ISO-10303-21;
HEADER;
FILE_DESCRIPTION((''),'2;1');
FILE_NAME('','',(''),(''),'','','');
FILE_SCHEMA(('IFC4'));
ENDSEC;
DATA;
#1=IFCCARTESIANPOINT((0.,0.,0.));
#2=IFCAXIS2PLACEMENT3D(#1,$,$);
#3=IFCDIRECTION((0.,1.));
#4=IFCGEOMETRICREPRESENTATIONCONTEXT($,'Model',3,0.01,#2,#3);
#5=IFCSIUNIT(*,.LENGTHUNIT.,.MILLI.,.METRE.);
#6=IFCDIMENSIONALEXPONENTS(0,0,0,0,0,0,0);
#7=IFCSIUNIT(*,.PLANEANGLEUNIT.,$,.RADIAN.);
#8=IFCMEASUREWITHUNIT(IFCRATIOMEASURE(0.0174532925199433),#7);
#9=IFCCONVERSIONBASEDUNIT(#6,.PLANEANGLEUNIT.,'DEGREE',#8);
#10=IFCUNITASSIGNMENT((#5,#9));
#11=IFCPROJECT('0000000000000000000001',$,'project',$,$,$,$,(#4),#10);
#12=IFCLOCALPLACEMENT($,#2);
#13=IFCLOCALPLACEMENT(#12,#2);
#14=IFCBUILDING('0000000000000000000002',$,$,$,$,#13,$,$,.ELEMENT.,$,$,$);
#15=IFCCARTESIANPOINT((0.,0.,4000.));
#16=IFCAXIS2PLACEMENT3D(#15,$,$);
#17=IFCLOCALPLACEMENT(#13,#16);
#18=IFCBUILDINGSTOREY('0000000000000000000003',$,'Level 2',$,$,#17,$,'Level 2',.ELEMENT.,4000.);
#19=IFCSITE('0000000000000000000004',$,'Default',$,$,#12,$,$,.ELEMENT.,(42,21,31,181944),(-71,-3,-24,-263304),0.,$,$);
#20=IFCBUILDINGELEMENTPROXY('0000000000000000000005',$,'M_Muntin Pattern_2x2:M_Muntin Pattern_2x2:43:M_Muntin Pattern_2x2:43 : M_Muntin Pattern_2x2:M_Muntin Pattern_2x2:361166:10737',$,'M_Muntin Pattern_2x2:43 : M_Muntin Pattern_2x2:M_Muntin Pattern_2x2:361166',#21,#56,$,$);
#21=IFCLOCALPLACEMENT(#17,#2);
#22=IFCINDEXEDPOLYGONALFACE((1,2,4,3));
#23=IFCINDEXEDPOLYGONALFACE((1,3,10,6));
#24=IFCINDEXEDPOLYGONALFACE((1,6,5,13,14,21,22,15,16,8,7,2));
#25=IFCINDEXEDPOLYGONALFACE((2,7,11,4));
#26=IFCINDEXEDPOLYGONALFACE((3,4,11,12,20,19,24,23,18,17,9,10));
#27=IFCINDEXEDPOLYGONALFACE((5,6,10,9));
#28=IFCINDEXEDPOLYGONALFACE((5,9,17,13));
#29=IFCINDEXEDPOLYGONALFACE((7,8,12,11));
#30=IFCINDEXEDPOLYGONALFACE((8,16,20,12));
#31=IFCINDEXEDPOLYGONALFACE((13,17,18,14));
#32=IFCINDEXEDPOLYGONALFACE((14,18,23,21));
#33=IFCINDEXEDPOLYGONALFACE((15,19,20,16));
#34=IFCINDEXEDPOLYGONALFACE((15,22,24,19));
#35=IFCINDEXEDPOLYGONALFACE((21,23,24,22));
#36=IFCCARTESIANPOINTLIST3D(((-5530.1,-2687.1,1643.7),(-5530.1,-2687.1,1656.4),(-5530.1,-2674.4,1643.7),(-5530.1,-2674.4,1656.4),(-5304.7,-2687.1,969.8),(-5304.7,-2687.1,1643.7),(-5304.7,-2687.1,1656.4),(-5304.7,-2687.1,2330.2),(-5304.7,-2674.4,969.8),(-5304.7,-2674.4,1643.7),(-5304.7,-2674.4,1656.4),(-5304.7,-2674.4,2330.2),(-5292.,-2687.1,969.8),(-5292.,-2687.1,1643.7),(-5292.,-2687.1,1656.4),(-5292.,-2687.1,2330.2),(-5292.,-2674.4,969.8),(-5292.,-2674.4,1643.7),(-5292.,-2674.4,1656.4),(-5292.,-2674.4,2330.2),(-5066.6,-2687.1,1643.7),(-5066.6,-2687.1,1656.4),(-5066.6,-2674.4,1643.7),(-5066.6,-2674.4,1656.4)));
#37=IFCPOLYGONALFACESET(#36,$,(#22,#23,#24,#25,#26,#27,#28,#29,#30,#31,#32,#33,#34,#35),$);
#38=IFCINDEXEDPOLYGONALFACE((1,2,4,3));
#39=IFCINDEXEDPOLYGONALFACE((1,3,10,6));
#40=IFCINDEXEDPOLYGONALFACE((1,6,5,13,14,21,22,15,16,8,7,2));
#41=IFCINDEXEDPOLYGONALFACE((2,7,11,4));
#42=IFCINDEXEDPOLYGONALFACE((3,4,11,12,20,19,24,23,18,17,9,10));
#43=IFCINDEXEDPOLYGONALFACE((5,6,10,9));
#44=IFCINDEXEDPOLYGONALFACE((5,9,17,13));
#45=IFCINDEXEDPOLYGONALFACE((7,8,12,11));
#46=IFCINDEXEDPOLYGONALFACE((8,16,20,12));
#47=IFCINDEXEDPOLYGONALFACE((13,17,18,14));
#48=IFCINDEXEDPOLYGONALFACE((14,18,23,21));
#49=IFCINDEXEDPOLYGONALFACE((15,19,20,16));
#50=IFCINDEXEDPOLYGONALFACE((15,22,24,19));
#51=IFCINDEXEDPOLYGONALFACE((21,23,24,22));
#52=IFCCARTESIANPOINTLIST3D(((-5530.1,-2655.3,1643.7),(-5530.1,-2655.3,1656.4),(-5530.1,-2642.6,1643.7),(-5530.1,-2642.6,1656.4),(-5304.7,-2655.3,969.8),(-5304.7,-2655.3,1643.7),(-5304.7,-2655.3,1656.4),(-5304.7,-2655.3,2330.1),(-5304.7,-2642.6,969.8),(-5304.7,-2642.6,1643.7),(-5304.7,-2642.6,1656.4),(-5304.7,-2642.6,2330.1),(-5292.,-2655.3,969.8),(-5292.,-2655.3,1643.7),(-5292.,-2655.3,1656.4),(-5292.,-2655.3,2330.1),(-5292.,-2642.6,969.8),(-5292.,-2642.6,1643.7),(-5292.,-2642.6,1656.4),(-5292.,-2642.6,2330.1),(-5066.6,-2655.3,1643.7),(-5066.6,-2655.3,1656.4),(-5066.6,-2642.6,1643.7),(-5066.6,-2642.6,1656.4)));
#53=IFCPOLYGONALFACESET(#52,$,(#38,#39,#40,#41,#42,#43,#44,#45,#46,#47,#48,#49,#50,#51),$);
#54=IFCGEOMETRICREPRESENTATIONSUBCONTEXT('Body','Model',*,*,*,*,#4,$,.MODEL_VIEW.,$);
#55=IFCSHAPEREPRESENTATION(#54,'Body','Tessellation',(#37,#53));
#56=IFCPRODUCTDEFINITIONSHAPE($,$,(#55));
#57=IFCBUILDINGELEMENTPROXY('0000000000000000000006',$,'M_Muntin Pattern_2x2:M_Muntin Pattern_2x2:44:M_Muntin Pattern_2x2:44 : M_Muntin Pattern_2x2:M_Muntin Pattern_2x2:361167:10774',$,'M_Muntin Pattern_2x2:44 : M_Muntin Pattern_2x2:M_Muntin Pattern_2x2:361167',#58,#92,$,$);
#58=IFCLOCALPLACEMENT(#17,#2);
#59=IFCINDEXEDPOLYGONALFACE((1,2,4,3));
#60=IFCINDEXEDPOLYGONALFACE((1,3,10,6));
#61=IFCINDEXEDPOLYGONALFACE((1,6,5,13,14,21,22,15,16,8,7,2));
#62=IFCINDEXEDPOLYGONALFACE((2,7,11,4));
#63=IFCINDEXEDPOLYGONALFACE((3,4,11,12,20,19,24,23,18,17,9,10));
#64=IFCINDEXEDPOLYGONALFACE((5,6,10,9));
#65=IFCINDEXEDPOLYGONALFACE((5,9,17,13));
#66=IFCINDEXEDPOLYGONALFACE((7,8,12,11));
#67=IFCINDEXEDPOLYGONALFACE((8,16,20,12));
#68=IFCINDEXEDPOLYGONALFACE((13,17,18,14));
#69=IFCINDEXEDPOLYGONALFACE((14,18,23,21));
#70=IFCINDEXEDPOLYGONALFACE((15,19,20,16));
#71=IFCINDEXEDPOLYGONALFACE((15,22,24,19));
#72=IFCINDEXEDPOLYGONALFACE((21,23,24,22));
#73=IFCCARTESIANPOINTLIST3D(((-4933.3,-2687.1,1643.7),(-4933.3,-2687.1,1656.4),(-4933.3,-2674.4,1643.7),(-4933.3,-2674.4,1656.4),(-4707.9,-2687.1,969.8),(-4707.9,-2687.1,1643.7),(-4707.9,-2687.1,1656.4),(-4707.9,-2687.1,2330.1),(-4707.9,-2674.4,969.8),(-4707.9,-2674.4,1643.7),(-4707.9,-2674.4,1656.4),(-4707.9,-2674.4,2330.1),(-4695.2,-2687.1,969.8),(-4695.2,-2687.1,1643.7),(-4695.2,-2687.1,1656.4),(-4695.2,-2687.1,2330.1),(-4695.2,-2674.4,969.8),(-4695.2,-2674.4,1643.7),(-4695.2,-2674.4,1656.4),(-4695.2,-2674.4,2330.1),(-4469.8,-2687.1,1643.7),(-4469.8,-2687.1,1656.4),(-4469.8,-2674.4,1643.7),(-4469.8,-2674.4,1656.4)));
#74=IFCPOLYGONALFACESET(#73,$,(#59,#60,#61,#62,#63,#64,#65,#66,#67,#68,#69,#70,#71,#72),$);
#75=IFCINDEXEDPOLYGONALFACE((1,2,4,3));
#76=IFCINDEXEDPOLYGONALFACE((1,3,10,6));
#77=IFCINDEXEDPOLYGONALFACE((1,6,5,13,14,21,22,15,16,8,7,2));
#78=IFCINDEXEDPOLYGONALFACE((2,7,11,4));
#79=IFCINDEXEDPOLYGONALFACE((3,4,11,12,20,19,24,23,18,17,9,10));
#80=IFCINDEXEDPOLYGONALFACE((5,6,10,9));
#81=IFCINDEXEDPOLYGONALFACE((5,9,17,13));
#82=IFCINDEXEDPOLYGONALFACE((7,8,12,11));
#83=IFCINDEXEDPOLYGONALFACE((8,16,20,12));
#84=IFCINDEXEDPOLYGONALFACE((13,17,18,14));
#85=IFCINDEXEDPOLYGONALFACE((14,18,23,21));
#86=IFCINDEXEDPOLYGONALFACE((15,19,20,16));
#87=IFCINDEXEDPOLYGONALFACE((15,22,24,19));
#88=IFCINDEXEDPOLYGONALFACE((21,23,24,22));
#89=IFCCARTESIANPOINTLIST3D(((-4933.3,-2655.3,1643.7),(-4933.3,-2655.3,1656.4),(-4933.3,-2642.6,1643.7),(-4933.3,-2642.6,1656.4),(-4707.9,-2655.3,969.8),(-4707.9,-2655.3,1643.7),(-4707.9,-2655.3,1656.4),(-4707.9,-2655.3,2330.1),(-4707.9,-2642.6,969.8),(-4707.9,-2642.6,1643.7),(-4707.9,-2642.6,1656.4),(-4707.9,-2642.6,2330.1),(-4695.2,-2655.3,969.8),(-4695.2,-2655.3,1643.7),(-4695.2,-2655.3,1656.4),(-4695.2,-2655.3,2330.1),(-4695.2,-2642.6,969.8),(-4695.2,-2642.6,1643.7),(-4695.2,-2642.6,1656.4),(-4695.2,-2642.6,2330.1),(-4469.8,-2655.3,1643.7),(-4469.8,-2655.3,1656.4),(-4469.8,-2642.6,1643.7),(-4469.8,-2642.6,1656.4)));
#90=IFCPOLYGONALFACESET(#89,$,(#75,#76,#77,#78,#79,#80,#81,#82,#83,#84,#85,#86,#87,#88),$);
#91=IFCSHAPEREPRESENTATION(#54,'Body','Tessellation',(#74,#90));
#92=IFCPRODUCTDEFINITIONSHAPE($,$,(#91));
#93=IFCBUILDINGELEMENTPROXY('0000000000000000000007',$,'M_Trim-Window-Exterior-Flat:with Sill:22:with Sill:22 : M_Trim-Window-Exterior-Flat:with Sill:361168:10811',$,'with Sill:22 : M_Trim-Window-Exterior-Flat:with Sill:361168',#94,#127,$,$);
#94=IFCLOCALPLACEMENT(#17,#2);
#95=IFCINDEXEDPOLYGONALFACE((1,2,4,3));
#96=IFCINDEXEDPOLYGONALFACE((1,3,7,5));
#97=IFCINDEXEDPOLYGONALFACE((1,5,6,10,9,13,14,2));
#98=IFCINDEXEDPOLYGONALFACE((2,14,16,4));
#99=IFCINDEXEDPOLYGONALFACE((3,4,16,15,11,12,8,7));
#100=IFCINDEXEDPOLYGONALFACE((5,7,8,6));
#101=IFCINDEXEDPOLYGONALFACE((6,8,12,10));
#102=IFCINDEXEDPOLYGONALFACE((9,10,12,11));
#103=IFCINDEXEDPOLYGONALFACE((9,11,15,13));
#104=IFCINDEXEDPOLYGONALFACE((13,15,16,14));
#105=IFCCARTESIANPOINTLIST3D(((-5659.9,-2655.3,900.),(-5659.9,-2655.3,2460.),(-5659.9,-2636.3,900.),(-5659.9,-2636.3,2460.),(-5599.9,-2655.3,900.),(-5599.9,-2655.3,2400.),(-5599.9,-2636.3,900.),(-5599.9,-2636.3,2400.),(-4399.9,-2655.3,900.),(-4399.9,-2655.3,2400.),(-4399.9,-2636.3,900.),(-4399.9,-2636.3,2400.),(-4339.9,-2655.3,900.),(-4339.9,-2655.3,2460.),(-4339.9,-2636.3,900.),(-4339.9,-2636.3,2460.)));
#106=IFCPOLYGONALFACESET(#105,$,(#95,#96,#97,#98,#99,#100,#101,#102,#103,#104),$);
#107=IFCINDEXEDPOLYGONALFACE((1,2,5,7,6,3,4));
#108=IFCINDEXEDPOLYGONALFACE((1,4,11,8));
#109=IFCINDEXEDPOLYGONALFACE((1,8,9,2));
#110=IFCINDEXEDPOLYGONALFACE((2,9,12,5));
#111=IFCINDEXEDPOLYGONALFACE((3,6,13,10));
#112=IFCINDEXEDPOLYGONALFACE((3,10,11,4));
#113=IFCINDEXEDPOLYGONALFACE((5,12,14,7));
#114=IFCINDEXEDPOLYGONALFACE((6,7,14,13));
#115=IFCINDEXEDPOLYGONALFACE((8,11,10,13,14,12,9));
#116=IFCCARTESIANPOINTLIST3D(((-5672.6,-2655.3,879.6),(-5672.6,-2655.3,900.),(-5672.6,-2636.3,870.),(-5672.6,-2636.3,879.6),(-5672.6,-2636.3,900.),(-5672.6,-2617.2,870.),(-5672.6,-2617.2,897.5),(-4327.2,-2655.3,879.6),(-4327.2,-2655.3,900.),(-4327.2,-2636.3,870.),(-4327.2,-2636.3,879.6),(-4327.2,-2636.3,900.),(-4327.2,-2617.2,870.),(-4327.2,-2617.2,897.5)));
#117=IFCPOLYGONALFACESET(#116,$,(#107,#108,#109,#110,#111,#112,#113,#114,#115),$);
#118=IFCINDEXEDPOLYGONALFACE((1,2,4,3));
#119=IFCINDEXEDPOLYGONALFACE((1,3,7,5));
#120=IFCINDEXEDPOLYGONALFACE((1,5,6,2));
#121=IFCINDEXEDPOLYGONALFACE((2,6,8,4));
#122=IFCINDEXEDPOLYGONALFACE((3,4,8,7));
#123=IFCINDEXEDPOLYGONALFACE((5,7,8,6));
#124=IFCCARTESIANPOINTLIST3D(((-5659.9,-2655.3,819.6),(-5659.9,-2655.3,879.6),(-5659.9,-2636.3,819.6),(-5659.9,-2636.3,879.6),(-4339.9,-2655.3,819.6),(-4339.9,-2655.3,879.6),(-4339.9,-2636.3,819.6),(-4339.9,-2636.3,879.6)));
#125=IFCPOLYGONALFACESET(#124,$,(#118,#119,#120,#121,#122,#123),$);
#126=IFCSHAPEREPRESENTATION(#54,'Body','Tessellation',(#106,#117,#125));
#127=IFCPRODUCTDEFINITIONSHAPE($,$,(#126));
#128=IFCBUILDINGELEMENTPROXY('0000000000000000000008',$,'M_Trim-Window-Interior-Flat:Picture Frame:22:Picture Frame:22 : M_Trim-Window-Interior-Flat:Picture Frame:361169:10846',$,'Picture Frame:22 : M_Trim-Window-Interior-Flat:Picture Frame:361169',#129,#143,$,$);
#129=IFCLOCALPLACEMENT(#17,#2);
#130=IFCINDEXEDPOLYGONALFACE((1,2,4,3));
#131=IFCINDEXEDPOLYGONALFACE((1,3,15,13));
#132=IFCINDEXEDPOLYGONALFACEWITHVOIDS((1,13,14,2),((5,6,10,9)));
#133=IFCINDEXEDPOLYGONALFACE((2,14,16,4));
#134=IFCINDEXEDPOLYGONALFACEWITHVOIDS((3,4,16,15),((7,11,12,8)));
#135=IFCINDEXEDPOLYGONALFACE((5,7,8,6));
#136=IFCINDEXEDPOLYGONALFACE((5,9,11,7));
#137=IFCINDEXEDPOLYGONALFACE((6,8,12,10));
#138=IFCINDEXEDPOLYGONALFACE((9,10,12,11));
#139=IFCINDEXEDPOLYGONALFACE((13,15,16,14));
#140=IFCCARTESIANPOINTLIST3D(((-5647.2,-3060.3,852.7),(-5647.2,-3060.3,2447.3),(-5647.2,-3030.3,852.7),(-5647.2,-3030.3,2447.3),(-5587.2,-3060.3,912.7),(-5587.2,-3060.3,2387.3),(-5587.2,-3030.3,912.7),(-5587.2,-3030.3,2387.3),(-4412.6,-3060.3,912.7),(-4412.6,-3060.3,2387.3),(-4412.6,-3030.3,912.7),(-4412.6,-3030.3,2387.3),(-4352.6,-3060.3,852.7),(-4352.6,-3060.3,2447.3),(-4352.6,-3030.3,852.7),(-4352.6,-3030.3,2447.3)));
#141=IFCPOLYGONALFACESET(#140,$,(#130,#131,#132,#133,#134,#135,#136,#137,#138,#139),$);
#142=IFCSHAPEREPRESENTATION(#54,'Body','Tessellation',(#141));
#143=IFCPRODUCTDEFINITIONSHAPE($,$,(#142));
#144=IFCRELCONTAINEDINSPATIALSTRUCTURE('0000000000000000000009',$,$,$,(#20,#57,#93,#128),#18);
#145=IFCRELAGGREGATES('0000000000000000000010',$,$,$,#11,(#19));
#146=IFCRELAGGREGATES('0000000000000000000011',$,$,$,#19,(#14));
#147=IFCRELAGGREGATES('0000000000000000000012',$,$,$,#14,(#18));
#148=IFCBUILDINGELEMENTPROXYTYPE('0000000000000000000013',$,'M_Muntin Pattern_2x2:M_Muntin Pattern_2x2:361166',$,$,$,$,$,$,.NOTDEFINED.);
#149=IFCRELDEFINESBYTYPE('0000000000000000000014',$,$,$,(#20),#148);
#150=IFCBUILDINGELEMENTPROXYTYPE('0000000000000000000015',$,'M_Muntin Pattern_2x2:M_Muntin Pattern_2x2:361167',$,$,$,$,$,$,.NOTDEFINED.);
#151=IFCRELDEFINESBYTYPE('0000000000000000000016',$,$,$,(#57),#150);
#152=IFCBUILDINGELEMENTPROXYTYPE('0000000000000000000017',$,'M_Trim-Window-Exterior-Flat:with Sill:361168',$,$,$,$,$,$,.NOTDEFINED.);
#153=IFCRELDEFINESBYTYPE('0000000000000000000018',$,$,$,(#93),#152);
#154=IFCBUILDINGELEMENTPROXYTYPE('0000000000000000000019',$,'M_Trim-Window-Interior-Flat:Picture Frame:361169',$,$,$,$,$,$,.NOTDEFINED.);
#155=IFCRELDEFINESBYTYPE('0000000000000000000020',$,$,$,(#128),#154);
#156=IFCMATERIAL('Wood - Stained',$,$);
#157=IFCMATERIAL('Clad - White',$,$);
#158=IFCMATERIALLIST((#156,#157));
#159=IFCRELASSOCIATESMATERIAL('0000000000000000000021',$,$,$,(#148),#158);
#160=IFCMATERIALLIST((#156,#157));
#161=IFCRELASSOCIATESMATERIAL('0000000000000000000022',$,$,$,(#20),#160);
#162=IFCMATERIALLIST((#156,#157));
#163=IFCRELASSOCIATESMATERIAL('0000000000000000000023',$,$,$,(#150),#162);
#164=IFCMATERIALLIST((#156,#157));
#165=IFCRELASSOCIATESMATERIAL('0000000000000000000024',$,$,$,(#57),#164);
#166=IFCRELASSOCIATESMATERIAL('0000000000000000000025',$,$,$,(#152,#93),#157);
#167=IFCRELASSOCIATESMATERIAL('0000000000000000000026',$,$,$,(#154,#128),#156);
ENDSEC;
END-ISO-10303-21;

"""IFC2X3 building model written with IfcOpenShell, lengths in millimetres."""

from ifc_helpers import new_model, entity, si_unit, converted_unit, direction, frame, frame_2d, origin, place, context, subcontext, project, spatial, polyline, rectangle, outline, extrude, source, transform, mapped, material, material_list, type_object, type_shapes, element, save


model = new_model("IFC2X3")

# Units and contexts
model_context = context("Model", 3, precision=0.01, world=origin(), true_north=direction((0.0, 1.0)))
body_context = subcontext(model_context, "Body", "Model", "MODEL_VIEW")
ifc_project = project(units=[si_unit("LENGTHUNIT", "METRE", prefix="MILLI"), converted_unit("PLANEANGLEUNIT", "DEGREE", entity("IfcRatioMeasure", 0.0174532925199433), si_unit("PLANEANGLEUNIT", "RADIAN"), dimensions=[0, 0, 0, 0, 0, 0, 0])], contexts=[model_context])

# Site, building, storey
site_placement = place(None, origin())
site = spatial("IfcSite", under=ifc_project, at=site_placement, Name="Default", CompositionType="ELEMENT", RefLatitude=(42, 21, 31, 181944), RefLongitude=(-71, -3, -24, -263304), RefElevation=0.0)
building_placement = place(site_placement, origin())
building = spatial("IfcBuilding", under=site, at=building_placement, CompositionType="ELEMENT")
storey_placement = place(building_placement, frame((0.0, 0.0, 4000.0)))
storey = spatial("IfcBuildingStorey", under=building, at=storey_placement, Name="Level 2", LongName="Level 2", CompositionType="ELEMENT", Elevation=4000.0)

# Building element proxies
ifc_material_1 = material(Name="Wood - Stained")
ifc_material_2 = material(Name="Clad - White")
ifc_material_list_1 = material_list([ifc_material_1, ifc_material_2])
ifc_material_list_2 = material_list([ifc_material_1, ifc_material_2])
building_element_proxy_type_1 = type_object("IfcBuildingElementProxyType", Name="M_Muntin Pattern_2x2:M_Muntin Pattern_2x2:361166", PredefinedType="NOTDEFINED", material=ifc_material_list_2)
shared_shape_1 = source(origin(), body_context, "Body", "SweptSolid", [
    extrude(outline(polyline([(-6.4, -680.2), (6.3, -680.2), (6.3, -6.4), (231.7, -6.4), (231.7, 6.3), (6.3, 6.3), (6.3, 680.2), (-6.4, 680.2), (-6.4, 6.3), (-231.7, 6.3), (-231.7, -6.4), (-6.4, -6.4), (-6.4, -680.2)])), frame((-5298.4, -2687.1, 5650.0), z_axis=(0.0, 1.0, 0.0), x_axis=(1.0, 0.0, 0.0)), (0.0, 0.0, 1.0), 12.7),
    extrude(outline(polyline([(-6.4, -680.1), (6.3, -680.1), (6.3, -6.4), (231.7, -6.4), (231.7, 6.3), (6.3, 6.3), (6.3, 680.2), (-6.4, 680.2), (-6.4, 6.3), (-231.7, 6.3), (-231.7, -6.4), (-6.4, -6.4), (-6.4, -680.1)])), frame((-5298.4, -2655.3, 5650.0), z_axis=(0.0, 1.0, 0.0), x_axis=(1.0, 0.0, 0.0)), (0.0, 0.0, 1.0), 12.7),
])
type_shapes(building_element_proxy_type_1, [shared_shape_1])
proxy_1_placement = place(storey_placement, frame((0.0, 0.0, -4000.0)))
element("IfcBuildingElementProxy", 1, at=proxy_1_placement, inside=storey, type_object=building_element_proxy_type_1, material=ifc_material_list_1, Name="M_Muntin Pattern_2x2:M_Muntin Pattern_2x2:43:M_Muntin Pattern_2x2:43 : M_Muntin Pattern_2x2:M_Muntin Pattern_2x2:361166:10737", ObjectType="M_Muntin Pattern_2x2:43 : M_Muntin Pattern_2x2:M_Muntin Pattern_2x2:361166", context=body_context, shape_type="MappedRepresentation", body=[
    mapped(shared_shape_1, transform((0.0, 0.0, 0.0), scale=1.0)),
])
ifc_material_list_3 = material_list([ifc_material_1, ifc_material_2])
ifc_material_list_4 = material_list([ifc_material_1, ifc_material_2])
building_element_proxy_type_2 = type_object("IfcBuildingElementProxyType", Name="M_Muntin Pattern_2x2:M_Muntin Pattern_2x2:361167", PredefinedType="NOTDEFINED", material=ifc_material_list_4)
shared_shape_2 = source(origin(), body_context, "Body", "SweptSolid", [
    extrude(outline(polyline([(-680.1, 6.4), (-680.1, -6.3), (-6.4, -6.3), (-6.4, -231.7), (6.3, -231.7), (6.3, -6.3), (680.2, -6.3), (680.2, 6.4), (6.3, 6.4), (6.3, 231.7), (-6.4, 231.7), (-6.4, 6.4), (-680.1, 6.4)])), frame((-4701.5, -2687.1, 5650.0), z_axis=(0.0, -1.0, 0.0), x_axis=(0.0, 0.0, -1.0)), (0.0, 0.0, -1.0), 12.7),
    extrude(outline(polyline([(-680.1, 6.4), (-680.1, -6.3), (-6.4, -6.3), (-6.4, -231.7), (6.3, -231.7), (6.3, -6.3), (680.2, -6.3), (680.2, 6.4), (6.3, 6.4), (6.3, 231.7), (-6.4, 231.7), (-6.4, 6.4), (-680.1, 6.4)])), frame((-4701.5, -2655.3, 5650.0), z_axis=(0.0, -1.0, 0.0), x_axis=(0.0, 0.0, -1.0)), (0.0, 0.0, -1.0), 12.7),
])
type_shapes(building_element_proxy_type_2, [shared_shape_2])
proxy_2_placement = place(storey_placement, frame((0.0, 0.0, -4000.0)))
element("IfcBuildingElementProxy", 2, at=proxy_2_placement, inside=storey, type_object=building_element_proxy_type_2, material=ifc_material_list_3, Name="M_Muntin Pattern_2x2:M_Muntin Pattern_2x2:44:M_Muntin Pattern_2x2:44 : M_Muntin Pattern_2x2:M_Muntin Pattern_2x2:361167:10774", ObjectType="M_Muntin Pattern_2x2:44 : M_Muntin Pattern_2x2:M_Muntin Pattern_2x2:361167", context=body_context, shape_type="MappedRepresentation", body=[
    mapped(shared_shape_2, transform((0.0, 0.0, 0.0), scale=1.0)),
])
building_element_proxy_type_3 = type_object("IfcBuildingElementProxyType", Name="M_Trim-Window-Exterior-Flat:with Sill:361168", PredefinedType="NOTDEFINED", material=ifc_material_2)
shared_shape_3 = source(origin(), body_context, "Body", "SweptSolid", [
    extrude(outline(polyline([(-660.0, -765.0), (-600.0, -765.0), (-600.0, 735.0), (600.0, 735.0), (600.0, -765.0), (660.0, -765.0), (660.0, 795.0), (-660.0, 795.0), (-660.0, -765.0)])), frame((-4999.9, -2655.3, 5665.0), z_axis=(0.0, 1.0, 0.0), x_axis=(-1.0, 0.0, 0.0)), (0.0, 0.0, 1.0), 19.1),
    extrude(outline(polyline([(0.0, -15.2), (19.0, -15.2), (19.0, 12.3), (0.0, 14.8), (-19.0, 14.8), (-19.0, -5.7), (0.0, -5.7), (0.0, -15.2)])), frame((-5672.6, -2636.3, 4885.2), z_axis=(1.0, 0.0, 0.0), x_axis=(0.0, 1.0, 0.0)), (0.0, 0.0, 1.0), 1345.4),
    extrude(rectangle(XDim=19.1, YDim=1320.0, at=frame_2d((0.0, 0.0), x_axis=(1.0, 0.0))), frame((-4999.9, -2645.8, 4819.6), z_axis=(0.0, 0.0, 1.0), x_axis=(0.0, -1.0, 0.0)), (0.0, 0.0, 1.0), 60.0),
])
type_shapes(building_element_proxy_type_3, [shared_shape_3])
proxy_3_placement = place(storey_placement, frame((0.0, 0.0, -4000.0)))
element("IfcBuildingElementProxy", 3, at=proxy_3_placement, inside=storey, type_object=building_element_proxy_type_3, material=ifc_material_2, Name="M_Trim-Window-Exterior-Flat:with Sill:22:with Sill:22 : M_Trim-Window-Exterior-Flat:with Sill:361168:10811", ObjectType="with Sill:22 : M_Trim-Window-Exterior-Flat:with Sill:361168", context=body_context, shape_type="MappedRepresentation", body=[
    mapped(shared_shape_3, transform((0.0, 0.0, 0.0), scale=1.0)),
])
building_element_proxy_type_4 = type_object("IfcBuildingElementProxyType", Name="M_Trim-Window-Interior-Flat:Picture Frame:361169", PredefinedType="NOTDEFINED", material=ifc_material_1)
shared_shape_4 = source(origin(), body_context, "Body", "SweptSolid", [
    extrude(outline(polyline([(-647.3, -797.3), (647.3, -797.3), (647.3, 797.3), (-647.3, 797.3), (-647.3, -797.3)]), holes=[polyline([(587.3, 737.3), (587.3, -737.3), (-587.3, -737.3), (-587.3, 737.3), (587.3, 737.3)])]), frame((-4999.9, -3060.3, 5650.0), z_axis=(0.0, 1.0, 0.0), x_axis=(1.0, 0.0, 0.0)), (0.0, 0.0, 1.0), 30.0),
])
type_shapes(building_element_proxy_type_4, [shared_shape_4])
proxy_4_placement = place(storey_placement, frame((0.0, 0.0, -4000.0)))
element("IfcBuildingElementProxy", 4, at=proxy_4_placement, inside=storey, type_object=building_element_proxy_type_4, material=ifc_material_1, Name="M_Trim-Window-Interior-Flat:Picture Frame:22:Picture Frame:22 : M_Trim-Window-Interior-Flat:Picture Frame:361169:10846", ObjectType="Picture Frame:22 : M_Trim-Window-Interior-Flat:Picture Frame:361169", context=body_context, shape_type="MappedRepresentation", body=[
    mapped(shared_shape_4, transform((0.0, 0.0, 0.0), scale=1.0)),
])

save(model, "model.ifc")
